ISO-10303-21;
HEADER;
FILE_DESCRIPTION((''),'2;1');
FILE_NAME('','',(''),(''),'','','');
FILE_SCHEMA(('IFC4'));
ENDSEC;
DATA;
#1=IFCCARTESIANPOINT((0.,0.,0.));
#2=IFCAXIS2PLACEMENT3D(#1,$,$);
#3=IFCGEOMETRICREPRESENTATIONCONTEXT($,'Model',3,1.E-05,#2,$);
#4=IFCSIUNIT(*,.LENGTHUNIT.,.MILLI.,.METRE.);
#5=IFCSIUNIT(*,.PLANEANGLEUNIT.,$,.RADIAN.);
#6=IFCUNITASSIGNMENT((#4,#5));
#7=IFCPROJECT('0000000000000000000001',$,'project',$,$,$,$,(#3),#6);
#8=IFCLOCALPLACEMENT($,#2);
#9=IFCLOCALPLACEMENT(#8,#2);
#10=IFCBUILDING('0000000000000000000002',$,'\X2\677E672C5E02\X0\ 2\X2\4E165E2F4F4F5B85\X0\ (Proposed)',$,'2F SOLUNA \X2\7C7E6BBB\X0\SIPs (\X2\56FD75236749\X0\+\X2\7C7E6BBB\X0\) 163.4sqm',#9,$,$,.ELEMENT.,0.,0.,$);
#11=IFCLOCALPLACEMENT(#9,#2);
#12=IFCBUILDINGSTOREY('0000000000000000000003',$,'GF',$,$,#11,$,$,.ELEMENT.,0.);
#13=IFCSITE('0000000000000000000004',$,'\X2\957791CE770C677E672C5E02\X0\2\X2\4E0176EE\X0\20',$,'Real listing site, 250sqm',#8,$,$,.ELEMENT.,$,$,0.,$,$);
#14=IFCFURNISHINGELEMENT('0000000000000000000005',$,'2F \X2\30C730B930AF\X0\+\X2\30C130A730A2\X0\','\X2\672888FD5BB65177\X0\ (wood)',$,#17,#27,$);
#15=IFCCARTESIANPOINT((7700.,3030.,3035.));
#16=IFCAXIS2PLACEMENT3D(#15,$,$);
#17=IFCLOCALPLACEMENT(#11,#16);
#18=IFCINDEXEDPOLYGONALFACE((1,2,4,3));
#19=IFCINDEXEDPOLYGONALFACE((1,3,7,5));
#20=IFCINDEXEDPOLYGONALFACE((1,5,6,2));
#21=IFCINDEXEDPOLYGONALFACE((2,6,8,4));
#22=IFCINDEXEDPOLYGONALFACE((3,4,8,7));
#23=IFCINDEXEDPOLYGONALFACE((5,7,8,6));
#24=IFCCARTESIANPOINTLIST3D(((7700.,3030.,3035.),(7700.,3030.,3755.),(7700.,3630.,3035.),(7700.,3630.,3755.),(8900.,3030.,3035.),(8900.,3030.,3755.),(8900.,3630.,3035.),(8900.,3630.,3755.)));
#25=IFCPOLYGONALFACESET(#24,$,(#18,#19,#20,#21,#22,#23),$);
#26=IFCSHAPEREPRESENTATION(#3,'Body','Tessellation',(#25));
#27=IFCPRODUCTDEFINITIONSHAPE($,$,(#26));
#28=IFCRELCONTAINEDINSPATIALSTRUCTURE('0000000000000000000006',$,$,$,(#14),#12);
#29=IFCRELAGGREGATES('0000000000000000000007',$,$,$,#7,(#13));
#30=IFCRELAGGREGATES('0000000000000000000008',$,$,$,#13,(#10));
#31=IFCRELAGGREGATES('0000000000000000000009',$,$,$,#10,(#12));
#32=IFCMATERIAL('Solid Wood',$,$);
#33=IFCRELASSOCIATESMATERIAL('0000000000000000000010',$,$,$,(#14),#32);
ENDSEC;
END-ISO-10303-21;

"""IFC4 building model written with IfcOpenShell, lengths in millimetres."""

from ifc_helpers import new_model, si_unit, frame, frame_2d, origin, place, context, project, spatial, rectangle, extrude, material, element, save


model = new_model("IFC4")

# Units and contexts
model_context = context("Model", 3, precision=1e-05, world=origin())
ifc_project = project(units=[si_unit("LENGTHUNIT", "METRE", prefix="MILLI"), si_unit("PLANEANGLEUNIT", "RADIAN")], contexts=[model_context])

# Site, building, storey
site_placement = place(None, origin())
site = spatial("IfcSite", under=ifc_project, at=site_placement, Name="長野県松本市2丁目20", ObjectType="Real listing site, 250sqm", CompositionType="ELEMENT", RefElevation=0.0)
building_placement = place(site_placement, origin())
building = spatial("IfcBuilding", under=site, at=building_placement, Name="松本市 2世帯住宅 (Proposed)", ObjectType="2F SOLUNA 籾殻SIPs (国産杉+籾殻) 163.4sqm", CompositionType="ELEMENT", ElevationOfRefHeight=0.0, ElevationOfTerrain=0.0)
storey_placement = place(building_placement, origin())
storey = spatial("IfcBuildingStorey", under=building, at=storey_placement, Name="GF", CompositionType="ELEMENT", Elevation=0.0)

# Shared definitions
ifc_material_1 = material(Name="Solid Wood")

# Furnishing element
furnishing_1_placement = place(storey_placement, frame((7700.0, 3030.0, 3035.0)))
element("IfcFurnishingElement", 1, at=furnishing_1_placement, inside=storey, material=ifc_material_1, Name="2F デスク+チェア", Description="木製家具 (wood)", context=model_context, shape_type="SweptSolid", body=[
    extrude(rectangle(XDim=1200.0, YDim=600.0, at=frame_2d((600.0, 300.0))), frame((7700.0, 3030.0, 3035.0)), (0.0, 0.0, 1.0), 720.0),
])

save(model, "model.ifc")
